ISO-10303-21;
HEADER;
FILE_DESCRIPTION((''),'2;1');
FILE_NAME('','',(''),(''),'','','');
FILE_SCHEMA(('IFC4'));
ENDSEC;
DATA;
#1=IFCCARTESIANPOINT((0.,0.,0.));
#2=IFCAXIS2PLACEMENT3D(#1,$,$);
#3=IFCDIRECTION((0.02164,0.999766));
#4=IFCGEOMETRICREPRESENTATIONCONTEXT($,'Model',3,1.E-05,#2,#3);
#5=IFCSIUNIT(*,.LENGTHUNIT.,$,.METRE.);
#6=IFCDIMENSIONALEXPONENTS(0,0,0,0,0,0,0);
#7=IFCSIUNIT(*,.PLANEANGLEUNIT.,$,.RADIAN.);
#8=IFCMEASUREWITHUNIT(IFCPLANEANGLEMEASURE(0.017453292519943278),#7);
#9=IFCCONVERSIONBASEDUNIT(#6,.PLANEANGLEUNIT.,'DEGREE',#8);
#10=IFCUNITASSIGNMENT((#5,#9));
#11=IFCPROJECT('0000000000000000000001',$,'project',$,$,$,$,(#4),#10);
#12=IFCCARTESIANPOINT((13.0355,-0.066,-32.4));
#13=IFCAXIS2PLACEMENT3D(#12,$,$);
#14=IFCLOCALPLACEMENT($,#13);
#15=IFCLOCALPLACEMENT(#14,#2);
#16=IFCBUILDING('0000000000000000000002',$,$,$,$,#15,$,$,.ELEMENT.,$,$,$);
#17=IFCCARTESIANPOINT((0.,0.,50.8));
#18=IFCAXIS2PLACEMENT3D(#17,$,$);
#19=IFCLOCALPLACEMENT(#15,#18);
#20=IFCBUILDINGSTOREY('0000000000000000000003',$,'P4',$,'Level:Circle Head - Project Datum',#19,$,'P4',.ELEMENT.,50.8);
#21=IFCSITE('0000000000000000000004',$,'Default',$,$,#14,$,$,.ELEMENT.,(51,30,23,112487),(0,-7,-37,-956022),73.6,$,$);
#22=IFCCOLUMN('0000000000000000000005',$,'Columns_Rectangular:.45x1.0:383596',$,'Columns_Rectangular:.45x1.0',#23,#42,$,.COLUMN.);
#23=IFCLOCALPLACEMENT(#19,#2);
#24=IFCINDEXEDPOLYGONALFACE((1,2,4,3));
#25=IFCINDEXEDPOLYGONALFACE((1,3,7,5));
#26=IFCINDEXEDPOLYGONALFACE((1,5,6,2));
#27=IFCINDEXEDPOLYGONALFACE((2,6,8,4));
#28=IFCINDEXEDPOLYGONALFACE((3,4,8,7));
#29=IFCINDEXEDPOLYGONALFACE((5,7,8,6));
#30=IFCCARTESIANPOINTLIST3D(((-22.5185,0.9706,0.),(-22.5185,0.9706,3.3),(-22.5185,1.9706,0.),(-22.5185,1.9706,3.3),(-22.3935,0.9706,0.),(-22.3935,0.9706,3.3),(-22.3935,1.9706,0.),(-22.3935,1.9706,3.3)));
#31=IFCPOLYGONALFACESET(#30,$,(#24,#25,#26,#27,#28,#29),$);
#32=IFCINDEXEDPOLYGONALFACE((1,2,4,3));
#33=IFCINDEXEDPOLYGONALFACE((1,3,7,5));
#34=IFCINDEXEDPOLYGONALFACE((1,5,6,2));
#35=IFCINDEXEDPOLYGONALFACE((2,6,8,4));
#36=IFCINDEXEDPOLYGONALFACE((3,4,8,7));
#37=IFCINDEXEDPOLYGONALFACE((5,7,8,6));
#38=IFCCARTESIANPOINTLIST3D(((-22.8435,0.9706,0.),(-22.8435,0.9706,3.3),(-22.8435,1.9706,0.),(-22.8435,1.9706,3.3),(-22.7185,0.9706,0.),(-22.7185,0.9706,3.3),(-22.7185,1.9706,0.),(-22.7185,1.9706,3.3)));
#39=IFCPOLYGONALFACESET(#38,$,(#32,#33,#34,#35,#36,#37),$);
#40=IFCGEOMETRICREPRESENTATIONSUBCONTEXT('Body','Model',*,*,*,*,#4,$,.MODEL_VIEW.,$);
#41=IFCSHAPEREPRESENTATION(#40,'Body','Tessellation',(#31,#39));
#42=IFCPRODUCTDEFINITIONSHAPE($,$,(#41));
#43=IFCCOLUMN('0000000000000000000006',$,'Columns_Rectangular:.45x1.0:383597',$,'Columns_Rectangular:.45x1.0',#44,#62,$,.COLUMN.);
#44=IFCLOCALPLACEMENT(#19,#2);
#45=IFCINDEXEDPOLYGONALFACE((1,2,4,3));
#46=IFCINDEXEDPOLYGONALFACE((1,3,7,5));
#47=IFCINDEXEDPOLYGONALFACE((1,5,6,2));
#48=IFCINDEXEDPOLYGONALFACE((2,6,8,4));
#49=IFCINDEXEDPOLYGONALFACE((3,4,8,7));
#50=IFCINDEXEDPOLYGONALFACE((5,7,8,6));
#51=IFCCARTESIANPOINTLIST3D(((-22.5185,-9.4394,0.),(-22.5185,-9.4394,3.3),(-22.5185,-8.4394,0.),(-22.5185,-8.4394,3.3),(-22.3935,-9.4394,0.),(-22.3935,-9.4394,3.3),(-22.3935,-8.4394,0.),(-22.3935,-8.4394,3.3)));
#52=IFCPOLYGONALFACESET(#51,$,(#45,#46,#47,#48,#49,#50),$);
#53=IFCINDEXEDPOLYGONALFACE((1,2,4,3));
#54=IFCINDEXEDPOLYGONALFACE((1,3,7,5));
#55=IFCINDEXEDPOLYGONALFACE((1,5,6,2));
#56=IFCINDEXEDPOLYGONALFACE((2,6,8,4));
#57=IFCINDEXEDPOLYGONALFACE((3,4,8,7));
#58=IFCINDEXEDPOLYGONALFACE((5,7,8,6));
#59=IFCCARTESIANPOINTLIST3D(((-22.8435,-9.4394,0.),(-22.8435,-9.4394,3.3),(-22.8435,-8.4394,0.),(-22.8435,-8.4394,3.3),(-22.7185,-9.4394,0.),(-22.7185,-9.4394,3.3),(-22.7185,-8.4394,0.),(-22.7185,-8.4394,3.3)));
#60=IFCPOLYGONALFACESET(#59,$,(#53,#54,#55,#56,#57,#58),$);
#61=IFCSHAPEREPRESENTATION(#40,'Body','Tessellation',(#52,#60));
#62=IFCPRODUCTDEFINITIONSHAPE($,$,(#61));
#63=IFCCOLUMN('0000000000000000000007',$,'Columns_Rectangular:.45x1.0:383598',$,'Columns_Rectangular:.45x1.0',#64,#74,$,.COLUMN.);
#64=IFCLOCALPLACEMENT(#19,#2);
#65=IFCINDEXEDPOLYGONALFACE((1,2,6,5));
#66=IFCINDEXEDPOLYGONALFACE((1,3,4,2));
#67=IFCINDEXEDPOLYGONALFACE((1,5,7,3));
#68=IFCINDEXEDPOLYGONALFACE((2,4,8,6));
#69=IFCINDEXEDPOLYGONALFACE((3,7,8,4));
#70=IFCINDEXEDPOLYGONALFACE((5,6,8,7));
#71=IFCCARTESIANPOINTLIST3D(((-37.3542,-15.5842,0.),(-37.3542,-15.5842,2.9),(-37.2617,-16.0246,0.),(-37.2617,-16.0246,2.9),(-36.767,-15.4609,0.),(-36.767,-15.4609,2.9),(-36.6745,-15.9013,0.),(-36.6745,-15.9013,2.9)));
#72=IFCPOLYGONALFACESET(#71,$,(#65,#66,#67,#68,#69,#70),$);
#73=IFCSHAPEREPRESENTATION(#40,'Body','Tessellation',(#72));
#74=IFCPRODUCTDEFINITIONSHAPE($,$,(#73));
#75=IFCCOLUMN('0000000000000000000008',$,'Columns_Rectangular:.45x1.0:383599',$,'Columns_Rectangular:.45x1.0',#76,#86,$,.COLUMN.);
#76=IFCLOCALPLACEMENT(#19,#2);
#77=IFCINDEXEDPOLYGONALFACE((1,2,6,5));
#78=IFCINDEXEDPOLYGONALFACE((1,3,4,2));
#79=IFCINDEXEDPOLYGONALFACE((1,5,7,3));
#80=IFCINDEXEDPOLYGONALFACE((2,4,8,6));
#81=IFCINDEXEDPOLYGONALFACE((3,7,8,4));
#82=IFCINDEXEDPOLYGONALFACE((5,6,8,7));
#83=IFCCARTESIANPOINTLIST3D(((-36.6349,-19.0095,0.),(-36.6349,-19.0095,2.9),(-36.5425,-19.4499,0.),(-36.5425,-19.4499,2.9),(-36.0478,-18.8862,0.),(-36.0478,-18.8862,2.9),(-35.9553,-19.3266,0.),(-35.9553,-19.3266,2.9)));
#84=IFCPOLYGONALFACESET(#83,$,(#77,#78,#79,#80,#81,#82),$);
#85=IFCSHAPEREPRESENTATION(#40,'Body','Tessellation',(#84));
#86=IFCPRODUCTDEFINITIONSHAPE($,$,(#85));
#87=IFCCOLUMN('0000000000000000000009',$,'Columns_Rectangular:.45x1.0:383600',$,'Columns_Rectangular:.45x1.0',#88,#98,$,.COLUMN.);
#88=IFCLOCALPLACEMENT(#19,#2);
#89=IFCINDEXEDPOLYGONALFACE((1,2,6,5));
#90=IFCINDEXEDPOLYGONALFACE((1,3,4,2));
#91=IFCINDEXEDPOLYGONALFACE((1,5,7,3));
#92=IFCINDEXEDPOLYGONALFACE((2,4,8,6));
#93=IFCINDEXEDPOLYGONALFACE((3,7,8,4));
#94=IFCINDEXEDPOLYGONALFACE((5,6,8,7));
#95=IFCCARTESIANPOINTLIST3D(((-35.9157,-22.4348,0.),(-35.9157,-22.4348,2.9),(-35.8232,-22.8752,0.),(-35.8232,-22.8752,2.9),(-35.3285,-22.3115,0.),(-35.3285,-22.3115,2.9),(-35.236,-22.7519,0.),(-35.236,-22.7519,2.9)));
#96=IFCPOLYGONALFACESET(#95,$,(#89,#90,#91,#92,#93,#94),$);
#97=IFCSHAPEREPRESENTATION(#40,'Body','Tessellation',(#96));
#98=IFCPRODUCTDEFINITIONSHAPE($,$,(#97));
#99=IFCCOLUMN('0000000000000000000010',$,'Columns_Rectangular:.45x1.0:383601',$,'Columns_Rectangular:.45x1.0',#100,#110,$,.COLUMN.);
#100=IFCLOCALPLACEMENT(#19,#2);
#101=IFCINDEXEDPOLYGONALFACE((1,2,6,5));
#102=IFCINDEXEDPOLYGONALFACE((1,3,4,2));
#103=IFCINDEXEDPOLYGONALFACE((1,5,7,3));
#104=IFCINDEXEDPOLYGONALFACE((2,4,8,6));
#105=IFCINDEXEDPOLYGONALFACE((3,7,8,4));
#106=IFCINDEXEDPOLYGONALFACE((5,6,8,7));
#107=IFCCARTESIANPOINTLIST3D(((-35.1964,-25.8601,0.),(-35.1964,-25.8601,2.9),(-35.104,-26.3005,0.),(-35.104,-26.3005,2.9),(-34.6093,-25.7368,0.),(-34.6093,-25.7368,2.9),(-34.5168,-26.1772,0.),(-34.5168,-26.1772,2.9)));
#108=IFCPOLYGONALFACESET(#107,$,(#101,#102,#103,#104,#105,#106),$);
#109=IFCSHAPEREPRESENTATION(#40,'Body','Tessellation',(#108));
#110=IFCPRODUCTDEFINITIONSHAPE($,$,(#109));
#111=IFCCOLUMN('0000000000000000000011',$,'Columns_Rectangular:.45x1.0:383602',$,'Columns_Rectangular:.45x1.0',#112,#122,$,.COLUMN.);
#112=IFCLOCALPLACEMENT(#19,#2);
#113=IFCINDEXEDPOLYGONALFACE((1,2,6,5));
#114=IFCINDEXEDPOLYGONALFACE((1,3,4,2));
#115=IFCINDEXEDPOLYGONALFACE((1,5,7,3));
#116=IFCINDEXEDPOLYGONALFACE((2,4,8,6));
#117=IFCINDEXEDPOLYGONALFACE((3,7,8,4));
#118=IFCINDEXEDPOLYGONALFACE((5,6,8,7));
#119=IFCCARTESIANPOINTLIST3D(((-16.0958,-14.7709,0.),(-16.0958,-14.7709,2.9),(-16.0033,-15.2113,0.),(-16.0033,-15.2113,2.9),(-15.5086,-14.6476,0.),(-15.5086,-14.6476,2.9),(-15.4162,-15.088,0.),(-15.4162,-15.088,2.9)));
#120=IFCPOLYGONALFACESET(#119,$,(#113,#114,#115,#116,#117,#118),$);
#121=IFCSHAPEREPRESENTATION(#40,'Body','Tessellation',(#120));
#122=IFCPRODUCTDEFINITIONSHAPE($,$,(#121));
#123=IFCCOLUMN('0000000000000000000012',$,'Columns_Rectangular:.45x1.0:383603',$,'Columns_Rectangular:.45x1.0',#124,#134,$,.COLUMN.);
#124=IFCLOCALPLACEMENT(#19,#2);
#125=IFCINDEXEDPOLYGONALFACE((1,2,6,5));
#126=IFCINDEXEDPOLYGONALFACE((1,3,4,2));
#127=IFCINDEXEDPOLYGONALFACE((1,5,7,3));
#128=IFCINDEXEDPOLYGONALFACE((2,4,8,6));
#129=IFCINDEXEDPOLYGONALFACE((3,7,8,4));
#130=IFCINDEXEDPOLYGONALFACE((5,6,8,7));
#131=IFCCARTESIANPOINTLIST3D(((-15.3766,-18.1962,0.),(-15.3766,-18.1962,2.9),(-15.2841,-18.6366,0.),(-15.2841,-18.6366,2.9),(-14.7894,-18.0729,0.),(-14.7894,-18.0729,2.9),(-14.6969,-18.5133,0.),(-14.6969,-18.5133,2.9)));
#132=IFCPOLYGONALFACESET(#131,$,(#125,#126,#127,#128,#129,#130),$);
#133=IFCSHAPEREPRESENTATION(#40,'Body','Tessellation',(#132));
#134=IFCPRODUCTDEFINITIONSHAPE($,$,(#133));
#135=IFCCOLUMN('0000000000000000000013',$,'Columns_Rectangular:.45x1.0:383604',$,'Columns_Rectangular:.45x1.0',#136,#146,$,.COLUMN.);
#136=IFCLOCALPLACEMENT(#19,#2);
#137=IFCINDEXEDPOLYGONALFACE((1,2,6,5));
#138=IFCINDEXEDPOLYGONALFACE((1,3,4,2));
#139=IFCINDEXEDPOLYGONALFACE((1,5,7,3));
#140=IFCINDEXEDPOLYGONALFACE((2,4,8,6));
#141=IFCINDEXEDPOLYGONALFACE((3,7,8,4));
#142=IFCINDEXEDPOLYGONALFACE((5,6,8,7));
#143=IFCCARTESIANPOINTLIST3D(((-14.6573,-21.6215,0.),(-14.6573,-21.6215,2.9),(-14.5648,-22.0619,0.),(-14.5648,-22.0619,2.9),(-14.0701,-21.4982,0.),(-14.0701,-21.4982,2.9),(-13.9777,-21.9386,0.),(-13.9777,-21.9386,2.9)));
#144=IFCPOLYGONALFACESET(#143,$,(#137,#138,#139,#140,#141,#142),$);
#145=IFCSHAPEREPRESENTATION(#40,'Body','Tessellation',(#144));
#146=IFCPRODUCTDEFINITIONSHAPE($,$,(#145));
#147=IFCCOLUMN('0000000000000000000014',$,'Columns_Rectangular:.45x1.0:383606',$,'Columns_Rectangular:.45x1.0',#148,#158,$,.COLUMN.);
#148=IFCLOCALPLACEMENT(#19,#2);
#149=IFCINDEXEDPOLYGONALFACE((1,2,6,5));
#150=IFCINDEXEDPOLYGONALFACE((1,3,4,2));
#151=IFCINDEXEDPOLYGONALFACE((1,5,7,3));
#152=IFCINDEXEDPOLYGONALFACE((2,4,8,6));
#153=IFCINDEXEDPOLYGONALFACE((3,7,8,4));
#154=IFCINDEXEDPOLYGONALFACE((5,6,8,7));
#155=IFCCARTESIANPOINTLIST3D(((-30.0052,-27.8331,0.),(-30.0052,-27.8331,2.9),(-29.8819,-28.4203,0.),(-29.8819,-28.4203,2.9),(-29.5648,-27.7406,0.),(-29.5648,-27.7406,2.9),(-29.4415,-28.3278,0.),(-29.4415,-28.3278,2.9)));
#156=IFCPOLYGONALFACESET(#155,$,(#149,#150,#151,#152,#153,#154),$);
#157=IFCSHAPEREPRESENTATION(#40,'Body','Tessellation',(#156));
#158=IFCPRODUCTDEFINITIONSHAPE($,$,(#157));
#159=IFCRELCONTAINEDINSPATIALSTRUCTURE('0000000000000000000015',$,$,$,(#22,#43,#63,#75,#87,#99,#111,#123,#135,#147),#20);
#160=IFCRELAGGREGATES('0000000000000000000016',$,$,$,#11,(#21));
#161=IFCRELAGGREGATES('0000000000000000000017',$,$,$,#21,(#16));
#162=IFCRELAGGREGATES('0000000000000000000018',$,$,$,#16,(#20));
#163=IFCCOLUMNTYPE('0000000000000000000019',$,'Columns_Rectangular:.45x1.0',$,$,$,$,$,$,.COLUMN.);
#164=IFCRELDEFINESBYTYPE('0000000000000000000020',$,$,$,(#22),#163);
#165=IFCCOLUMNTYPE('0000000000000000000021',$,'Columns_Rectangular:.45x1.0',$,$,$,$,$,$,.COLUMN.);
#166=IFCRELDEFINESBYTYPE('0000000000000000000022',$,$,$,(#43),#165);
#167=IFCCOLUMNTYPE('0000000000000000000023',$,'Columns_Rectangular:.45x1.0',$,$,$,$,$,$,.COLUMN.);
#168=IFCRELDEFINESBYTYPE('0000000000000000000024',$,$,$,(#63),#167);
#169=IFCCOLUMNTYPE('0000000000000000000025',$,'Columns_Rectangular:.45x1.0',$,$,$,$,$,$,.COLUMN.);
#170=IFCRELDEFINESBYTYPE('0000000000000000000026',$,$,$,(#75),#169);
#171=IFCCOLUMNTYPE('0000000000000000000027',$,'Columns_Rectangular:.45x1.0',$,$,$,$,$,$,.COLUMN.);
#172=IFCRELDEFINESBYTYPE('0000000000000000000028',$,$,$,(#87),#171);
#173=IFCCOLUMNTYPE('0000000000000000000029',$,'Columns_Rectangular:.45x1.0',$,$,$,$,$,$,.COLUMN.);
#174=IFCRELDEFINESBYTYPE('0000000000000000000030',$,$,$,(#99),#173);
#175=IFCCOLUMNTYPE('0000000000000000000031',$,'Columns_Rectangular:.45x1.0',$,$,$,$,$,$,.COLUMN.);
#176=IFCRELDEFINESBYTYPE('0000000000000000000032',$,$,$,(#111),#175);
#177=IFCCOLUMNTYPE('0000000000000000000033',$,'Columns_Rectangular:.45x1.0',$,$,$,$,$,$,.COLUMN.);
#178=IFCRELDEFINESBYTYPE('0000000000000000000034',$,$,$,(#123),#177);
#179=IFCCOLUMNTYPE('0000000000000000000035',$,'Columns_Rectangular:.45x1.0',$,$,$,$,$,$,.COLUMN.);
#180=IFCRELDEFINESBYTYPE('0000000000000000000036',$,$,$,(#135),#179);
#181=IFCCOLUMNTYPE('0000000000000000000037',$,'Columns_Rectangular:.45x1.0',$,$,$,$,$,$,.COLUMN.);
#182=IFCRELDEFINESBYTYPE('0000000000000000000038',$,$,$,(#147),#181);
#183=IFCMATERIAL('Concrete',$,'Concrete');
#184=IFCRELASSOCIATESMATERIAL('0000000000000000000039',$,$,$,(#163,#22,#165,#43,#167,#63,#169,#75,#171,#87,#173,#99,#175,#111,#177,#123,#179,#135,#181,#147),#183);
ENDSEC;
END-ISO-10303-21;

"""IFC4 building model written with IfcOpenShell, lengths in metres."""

from ifc_helpers import new_model, entity, si_unit, converted_unit, direction, frame, origin, place, context, subcontext, project, spatial, indexed_curve, outline, extrude, source, transform, mapped, material, type_object, type_shapes, element, save


model = new_model("IFC4")

# Units and contexts
model_context = context("Model", 3, precision=1e-05, world=origin(), true_north=direction((0.02164, 0.999766)))
body_context = subcontext(model_context, "Body", "Model", "MODEL_VIEW")
ifc_project = project(units=[si_unit("LENGTHUNIT", "METRE"), converted_unit("PLANEANGLEUNIT", "DEGREE", entity("IfcPlaneAngleMeasure", 0.017453292519943278), si_unit("PLANEANGLEUNIT", "RADIAN"), dimensions=[0, 0, 0, 0, 0, 0, 0])], contexts=[model_context])

# Site, building, storey
site_placement = place(None, frame((13.0355, -0.066, -32.4)))
site = spatial("IfcSite", under=ifc_project, at=site_placement, Name="Default", CompositionType="ELEMENT", RefLatitude=(51, 30, 23, 112487), RefLongitude=(0, -7, -37, -956022), RefElevation=73.6)
building_placement = place(site_placement, origin())
building = spatial("IfcBuilding", under=site, at=building_placement, CompositionType="ELEMENT")
storey_placement = place(building_placement, frame((0.0, 0.0, 50.8)))
storey = spatial("IfcBuildingStorey", under=building, at=storey_placement, Name="P4", ObjectType="Level:Circle Head - Project Datum", LongName="P4", CompositionType="ELEMENT", Elevation=50.8)

# Columns
ifc_material = material(Name="Concrete", Category="Concrete")
column_type_1 = type_object("IfcColumnType", Name="Columns_Rectangular:.45x1.0", PredefinedType="COLUMN", material=ifc_material)
shared_shape_1 = source(origin(), body_context, "Body", "SweptSolid", [
    extrude(outline(indexed_curve([(-0.0625, -0.5), (0.0625, -0.5), (0.0625, 0.5), (-0.0625, 0.5), (-0.0625, -0.5)], self_intersect=False)), frame((-22.456, 1.4706, 50.8), z_axis=(0.0, 0.0, 1.0), x_axis=(-1.0, 0.0, 0.0)), (0.0, 0.0, 1.0), 3.3),
    extrude(outline(indexed_curve([(-0.0625, -0.5), (0.0625, -0.5), (0.0625, 0.5), (-0.0625, 0.5), (-0.0625, -0.5)], self_intersect=False)), frame((-22.781, 1.4706, 50.8)), (0.0, 0.0, 1.0), 3.3),
])
type_shapes(column_type_1, [shared_shape_1])
column_1_placement = place(storey_placement, frame((0.0, 0.0, -50.8)))
element("IfcColumn", 1, at=column_1_placement, inside=storey, type_object=column_type_1, material=ifc_material, Name="Columns_Rectangular:.45x1.0:383596", ObjectType="Columns_Rectangular:.45x1.0", PredefinedType="COLUMN", context=body_context, shape_type="MappedRepresentation", body=[
    mapped(shared_shape_1, transform((0.0, 0.0, 0.0), scale=1.0)),
])
column_type_2 = type_object("IfcColumnType", Name="Columns_Rectangular:.45x1.0", PredefinedType="COLUMN", material=ifc_material)
shared_shape_2 = source(origin(), body_context, "Body", "SweptSolid", [
    extrude(outline(indexed_curve([(-0.0625, -0.5), (0.0625, -0.5), (0.0625, 0.5), (-0.0625, 0.5), (-0.0625, -0.5)], self_intersect=False)), frame((-22.456, -8.9394, 50.8), z_axis=(0.0, 0.0, 1.0), x_axis=(-1.0, 0.0, 0.0)), (0.0, 0.0, 1.0), 3.3),
    extrude(outline(indexed_curve([(-0.0625, -0.5), (0.0625, -0.5), (0.0625, 0.5), (-0.0625, 0.5), (-0.0625, -0.5)], self_intersect=False)), frame((-22.781, -8.9394, 50.8)), (0.0, 0.0, 1.0), 3.3),
])
type_shapes(column_type_2, [shared_shape_2])
column_2_placement = place(storey_placement, frame((0.0, 0.0, -50.8)))
element("IfcColumn", 2, at=column_2_placement, inside=storey, type_object=column_type_2, material=ifc_material, Name="Columns_Rectangular:.45x1.0:383597", ObjectType="Columns_Rectangular:.45x1.0", PredefinedType="COLUMN", context=body_context, shape_type="MappedRepresentation", body=[
    mapped(shared_shape_2, transform((0.0, 0.0, 0.0), scale=1.0)),
])
column_type_3 = type_object("IfcColumnType", Name="Columns_Rectangular:.45x1.0", PredefinedType="COLUMN", material=ifc_material)
shared_shape_3 = source(origin(), body_context, "Body", "SweptSolid", [
    extrude(outline(indexed_curve([(-0.3, -0.225), (0.3, -0.225), (0.3, 0.225), (-0.3, 0.225), (-0.3, -0.225)], self_intersect=False)), frame((-37.0144, -15.7427, 50.8), z_axis=(0.0, 0.0, 1.0), x_axis=(0.978657, 0.2055, 0.0)), (0.0, 0.0, 1.0), 2.9),
])
type_shapes(column_type_3, [shared_shape_3])
column_3_placement = place(storey_placement, frame((0.0, 0.0, -50.8)))
element("IfcColumn", 3, at=column_3_placement, inside=storey, type_object=column_type_3, material=ifc_material, Name="Columns_Rectangular:.45x1.0:383598", ObjectType="Columns_Rectangular:.45x1.0", PredefinedType="COLUMN", context=body_context, shape_type="MappedRepresentation", body=[
    mapped(shared_shape_3, transform((0.0, 0.0, 0.0), scale=1.0)),
])
column_type_4 = type_object("IfcColumnType", Name="Columns_Rectangular:.45x1.0", PredefinedType="COLUMN", material=ifc_material)
shared_shape_4 = source(origin(), body_context, "Body", "SweptSolid", [
    extrude(outline(indexed_curve([(-0.3, -0.225), (0.3, -0.225), (0.3, 0.225), (-0.3, 0.225), (-0.3, -0.225)], self_intersect=False)), frame((-36.2951, -19.168, 50.8), z_axis=(0.0, 0.0, 1.0), x_axis=(0.978657, 0.2055, 0.0)), (0.0, 0.0, 1.0), 2.9),
])
type_shapes(column_type_4, [shared_shape_4])
column_4_placement = place(storey_placement, frame((0.0, 0.0, -50.8)))
element("IfcColumn", 4, at=column_4_placement, inside=storey, type_object=column_type_4, material=ifc_material, Name="Columns_Rectangular:.45x1.0:383599", ObjectType="Columns_Rectangular:.45x1.0", PredefinedType="COLUMN", context=body_context, shape_type="MappedRepresentation", body=[
    mapped(shared_shape_4, transform((0.0, 0.0, 0.0), scale=1.0)),
])
column_type_5 = type_object("IfcColumnType", Name="Columns_Rectangular:.45x1.0", PredefinedType="COLUMN", material=ifc_material)
shared_shape_5 = source(origin(), body_context, "Body", "SweptSolid", [
    extrude(outline(indexed_curve([(-0.3, -0.225), (0.3, -0.225), (0.3, 0.225), (-0.3, 0.225), (-0.3, -0.225)], self_intersect=False)), frame((-35.5759, -22.5933, 50.8), z_axis=(0.0, 0.0, 1.0), x_axis=(0.978657, 0.2055, 0.0)), (0.0, 0.0, 1.0), 2.9),
])
type_shapes(column_type_5, [shared_shape_5])
column_5_placement = place(storey_placement, frame((0.0, 0.0, -50.8)))
element("IfcColumn", 5, at=column_5_placement, inside=storey, type_object=column_type_5, material=ifc_material, Name="Columns_Rectangular:.45x1.0:383600", ObjectType="Columns_Rectangular:.45x1.0", PredefinedType="COLUMN", context=body_context, shape_type="MappedRepresentation", body=[
    mapped(shared_shape_5, transform((0.0, 0.0, 0.0), scale=1.0)),
])
column_type_6 = type_object("IfcColumnType", Name="Columns_Rectangular:.45x1.0", PredefinedType="COLUMN", material=ifc_material)
shared_shape_6 = source(origin(), body_context, "Body", "SweptSolid", [
    extrude(outline(indexed_curve([(-0.3, -0.225), (0.3, -0.225), (0.3, 0.225), (-0.3, 0.225), (-0.3, -0.225)], self_intersect=False)), frame((-34.8566, -26.0186, 50.8), z_axis=(0.0, 0.0, 1.0), x_axis=(0.978657, 0.2055, 0.0)), (0.0, 0.0, 1.0), 2.9),
])
type_shapes(column_type_6, [shared_shape_6])
column_6_placement = place(storey_placement, frame((0.0, 0.0, -50.8)))
element("IfcColumn", 6, at=column_6_placement, inside=storey, type_object=column_type_6, material=ifc_material, Name="Columns_Rectangular:.45x1.0:383601", ObjectType="Columns_Rectangular:.45x1.0", PredefinedType="COLUMN", context=body_context, shape_type="MappedRepresentation", body=[
    mapped(shared_shape_6, transform((0.0, 0.0, 0.0), scale=1.0)),
])
column_type_7 = type_object("IfcColumnType", Name="Columns_Rectangular:.45x1.0", PredefinedType="COLUMN", material=ifc_material)
shared_shape_7 = source(origin(), body_context, "Body", "SweptSolid", [
    extrude(outline(indexed_curve([(-1.45, -0.3), (1.45, -0.3), (1.45, 0.3), (-1.45, 0.3), (-1.45, -0.3)], self_intersect=False)), frame((-15.7098, -15.1497, 52.25), z_axis=(-0.2055, 0.978657, 0.0), x_axis=(0.0, 0.0, 1.0)), (0.0, 0.0, 1.0), 0.45),
])
type_shapes(column_type_7, [shared_shape_7])
column_7_placement = place(storey_placement, frame((0.0, 0.0, -50.8)))
element("IfcColumn", 7, at=column_7_placement, inside=storey, type_object=column_type_7, material=ifc_material, Name="Columns_Rectangular:.45x1.0:383602", ObjectType="Columns_Rectangular:.45x1.0", PredefinedType="COLUMN", context=body_context, shape_type="MappedRepresentation", body=[
    mapped(shared_shape_7, transform((0.0, 0.0, 0.0), scale=1.0)),
])
column_type_8 = type_object("IfcColumnType", Name="Columns_Rectangular:.45x1.0", PredefinedType="COLUMN", material=ifc_material)
shared_shape_8 = source(origin(), body_context, "Body", "SweptSolid", [
    extrude(outline(indexed_curve([(-1.45, -0.3), (1.45, -0.3), (1.45, 0.3), (-1.45, 0.3), (-1.45, -0.3)], self_intersect=False)), frame((-14.9905, -18.575, 52.25), z_axis=(-0.2055, 0.978657, 0.0), x_axis=(0.0, 0.0, 1.0)), (0.0, 0.0, 1.0), 0.45),
])
type_shapes(column_type_8, [shared_shape_8])
column_8_placement = place(storey_placement, frame((0.0, 0.0, -50.8)))
element("IfcColumn", 8, at=column_8_placement, inside=storey, type_object=column_type_8, material=ifc_material, Name="Columns_Rectangular:.45x1.0:383603", ObjectType="Columns_Rectangular:.45x1.0", PredefinedType="COLUMN", context=body_context, shape_type="MappedRepresentation", body=[
    mapped(shared_shape_8, transform((0.0, 0.0, 0.0), scale=1.0)),
])
column_type_9 = type_object("IfcColumnType", Name="Columns_Rectangular:.45x1.0", PredefinedType="COLUMN", material=ifc_material)
shared_shape_9 = source(origin(), body_context, "Body", "SweptSolid", [
    extrude(outline(indexed_curve([(-1.45, -0.3), (1.45, -0.3), (1.45, 0.3), (-1.45, 0.3), (-1.45, -0.3)], self_intersect=False)), frame((-14.2713, -22.0003, 52.25), z_axis=(-0.2055, 0.978657, 0.0), x_axis=(0.0, 0.0, 1.0)), (0.0, 0.0, 1.0), 0.45),
])
type_shapes(column_type_9, [shared_shape_9])
column_9_placement = place(storey_placement, frame((0.0, 0.0, -50.8)))
element("IfcColumn", 9, at=column_9_placement, inside=storey, type_object=column_type_9, material=ifc_material, Name="Columns_Rectangular:.45x1.0:383604", ObjectType="Columns_Rectangular:.45x1.0", PredefinedType="COLUMN", context=body_context, shape_type="MappedRepresentation", body=[
    mapped(shared_shape_9, transform((0.0, 0.0, 0.0), scale=1.0)),
])
column_type_10 = type_object("IfcColumnType", Name="Columns_Rectangular:.45x1.0", PredefinedType="COLUMN", material=ifc_material)
shared_shape_10 = source(origin(), body_context, "Body", "SweptSolid", [
    extrude(outline(indexed_curve([(-1.45, -0.3), (1.45, -0.3), (1.45, 0.3), (-1.45, 0.3), (-1.45, -0.3)], self_intersect=False)), frame((-29.9436, -28.1267, 52.25), z_axis=(0.978657, 0.2055, 0.0), x_axis=(0.0, 0.0, 1.0)), (0.0, 0.0, 1.0), 0.45),
])
type_shapes(column_type_10, [shared_shape_10])
column_10_placement = place(storey_placement, frame((0.0, 0.0, -50.8)))
element("IfcColumn", 10, at=column_10_placement, inside=storey, type_object=column_type_10, material=ifc_material, Name="Columns_Rectangular:.45x1.0:383606", ObjectType="Columns_Rectangular:.45x1.0", PredefinedType="COLUMN", context=body_context, shape_type="MappedRepresentation", body=[
    mapped(shared_shape_10, transform((0.0, 0.0, 0.0), scale=1.0)),
])

save(model, "model.ifc")
